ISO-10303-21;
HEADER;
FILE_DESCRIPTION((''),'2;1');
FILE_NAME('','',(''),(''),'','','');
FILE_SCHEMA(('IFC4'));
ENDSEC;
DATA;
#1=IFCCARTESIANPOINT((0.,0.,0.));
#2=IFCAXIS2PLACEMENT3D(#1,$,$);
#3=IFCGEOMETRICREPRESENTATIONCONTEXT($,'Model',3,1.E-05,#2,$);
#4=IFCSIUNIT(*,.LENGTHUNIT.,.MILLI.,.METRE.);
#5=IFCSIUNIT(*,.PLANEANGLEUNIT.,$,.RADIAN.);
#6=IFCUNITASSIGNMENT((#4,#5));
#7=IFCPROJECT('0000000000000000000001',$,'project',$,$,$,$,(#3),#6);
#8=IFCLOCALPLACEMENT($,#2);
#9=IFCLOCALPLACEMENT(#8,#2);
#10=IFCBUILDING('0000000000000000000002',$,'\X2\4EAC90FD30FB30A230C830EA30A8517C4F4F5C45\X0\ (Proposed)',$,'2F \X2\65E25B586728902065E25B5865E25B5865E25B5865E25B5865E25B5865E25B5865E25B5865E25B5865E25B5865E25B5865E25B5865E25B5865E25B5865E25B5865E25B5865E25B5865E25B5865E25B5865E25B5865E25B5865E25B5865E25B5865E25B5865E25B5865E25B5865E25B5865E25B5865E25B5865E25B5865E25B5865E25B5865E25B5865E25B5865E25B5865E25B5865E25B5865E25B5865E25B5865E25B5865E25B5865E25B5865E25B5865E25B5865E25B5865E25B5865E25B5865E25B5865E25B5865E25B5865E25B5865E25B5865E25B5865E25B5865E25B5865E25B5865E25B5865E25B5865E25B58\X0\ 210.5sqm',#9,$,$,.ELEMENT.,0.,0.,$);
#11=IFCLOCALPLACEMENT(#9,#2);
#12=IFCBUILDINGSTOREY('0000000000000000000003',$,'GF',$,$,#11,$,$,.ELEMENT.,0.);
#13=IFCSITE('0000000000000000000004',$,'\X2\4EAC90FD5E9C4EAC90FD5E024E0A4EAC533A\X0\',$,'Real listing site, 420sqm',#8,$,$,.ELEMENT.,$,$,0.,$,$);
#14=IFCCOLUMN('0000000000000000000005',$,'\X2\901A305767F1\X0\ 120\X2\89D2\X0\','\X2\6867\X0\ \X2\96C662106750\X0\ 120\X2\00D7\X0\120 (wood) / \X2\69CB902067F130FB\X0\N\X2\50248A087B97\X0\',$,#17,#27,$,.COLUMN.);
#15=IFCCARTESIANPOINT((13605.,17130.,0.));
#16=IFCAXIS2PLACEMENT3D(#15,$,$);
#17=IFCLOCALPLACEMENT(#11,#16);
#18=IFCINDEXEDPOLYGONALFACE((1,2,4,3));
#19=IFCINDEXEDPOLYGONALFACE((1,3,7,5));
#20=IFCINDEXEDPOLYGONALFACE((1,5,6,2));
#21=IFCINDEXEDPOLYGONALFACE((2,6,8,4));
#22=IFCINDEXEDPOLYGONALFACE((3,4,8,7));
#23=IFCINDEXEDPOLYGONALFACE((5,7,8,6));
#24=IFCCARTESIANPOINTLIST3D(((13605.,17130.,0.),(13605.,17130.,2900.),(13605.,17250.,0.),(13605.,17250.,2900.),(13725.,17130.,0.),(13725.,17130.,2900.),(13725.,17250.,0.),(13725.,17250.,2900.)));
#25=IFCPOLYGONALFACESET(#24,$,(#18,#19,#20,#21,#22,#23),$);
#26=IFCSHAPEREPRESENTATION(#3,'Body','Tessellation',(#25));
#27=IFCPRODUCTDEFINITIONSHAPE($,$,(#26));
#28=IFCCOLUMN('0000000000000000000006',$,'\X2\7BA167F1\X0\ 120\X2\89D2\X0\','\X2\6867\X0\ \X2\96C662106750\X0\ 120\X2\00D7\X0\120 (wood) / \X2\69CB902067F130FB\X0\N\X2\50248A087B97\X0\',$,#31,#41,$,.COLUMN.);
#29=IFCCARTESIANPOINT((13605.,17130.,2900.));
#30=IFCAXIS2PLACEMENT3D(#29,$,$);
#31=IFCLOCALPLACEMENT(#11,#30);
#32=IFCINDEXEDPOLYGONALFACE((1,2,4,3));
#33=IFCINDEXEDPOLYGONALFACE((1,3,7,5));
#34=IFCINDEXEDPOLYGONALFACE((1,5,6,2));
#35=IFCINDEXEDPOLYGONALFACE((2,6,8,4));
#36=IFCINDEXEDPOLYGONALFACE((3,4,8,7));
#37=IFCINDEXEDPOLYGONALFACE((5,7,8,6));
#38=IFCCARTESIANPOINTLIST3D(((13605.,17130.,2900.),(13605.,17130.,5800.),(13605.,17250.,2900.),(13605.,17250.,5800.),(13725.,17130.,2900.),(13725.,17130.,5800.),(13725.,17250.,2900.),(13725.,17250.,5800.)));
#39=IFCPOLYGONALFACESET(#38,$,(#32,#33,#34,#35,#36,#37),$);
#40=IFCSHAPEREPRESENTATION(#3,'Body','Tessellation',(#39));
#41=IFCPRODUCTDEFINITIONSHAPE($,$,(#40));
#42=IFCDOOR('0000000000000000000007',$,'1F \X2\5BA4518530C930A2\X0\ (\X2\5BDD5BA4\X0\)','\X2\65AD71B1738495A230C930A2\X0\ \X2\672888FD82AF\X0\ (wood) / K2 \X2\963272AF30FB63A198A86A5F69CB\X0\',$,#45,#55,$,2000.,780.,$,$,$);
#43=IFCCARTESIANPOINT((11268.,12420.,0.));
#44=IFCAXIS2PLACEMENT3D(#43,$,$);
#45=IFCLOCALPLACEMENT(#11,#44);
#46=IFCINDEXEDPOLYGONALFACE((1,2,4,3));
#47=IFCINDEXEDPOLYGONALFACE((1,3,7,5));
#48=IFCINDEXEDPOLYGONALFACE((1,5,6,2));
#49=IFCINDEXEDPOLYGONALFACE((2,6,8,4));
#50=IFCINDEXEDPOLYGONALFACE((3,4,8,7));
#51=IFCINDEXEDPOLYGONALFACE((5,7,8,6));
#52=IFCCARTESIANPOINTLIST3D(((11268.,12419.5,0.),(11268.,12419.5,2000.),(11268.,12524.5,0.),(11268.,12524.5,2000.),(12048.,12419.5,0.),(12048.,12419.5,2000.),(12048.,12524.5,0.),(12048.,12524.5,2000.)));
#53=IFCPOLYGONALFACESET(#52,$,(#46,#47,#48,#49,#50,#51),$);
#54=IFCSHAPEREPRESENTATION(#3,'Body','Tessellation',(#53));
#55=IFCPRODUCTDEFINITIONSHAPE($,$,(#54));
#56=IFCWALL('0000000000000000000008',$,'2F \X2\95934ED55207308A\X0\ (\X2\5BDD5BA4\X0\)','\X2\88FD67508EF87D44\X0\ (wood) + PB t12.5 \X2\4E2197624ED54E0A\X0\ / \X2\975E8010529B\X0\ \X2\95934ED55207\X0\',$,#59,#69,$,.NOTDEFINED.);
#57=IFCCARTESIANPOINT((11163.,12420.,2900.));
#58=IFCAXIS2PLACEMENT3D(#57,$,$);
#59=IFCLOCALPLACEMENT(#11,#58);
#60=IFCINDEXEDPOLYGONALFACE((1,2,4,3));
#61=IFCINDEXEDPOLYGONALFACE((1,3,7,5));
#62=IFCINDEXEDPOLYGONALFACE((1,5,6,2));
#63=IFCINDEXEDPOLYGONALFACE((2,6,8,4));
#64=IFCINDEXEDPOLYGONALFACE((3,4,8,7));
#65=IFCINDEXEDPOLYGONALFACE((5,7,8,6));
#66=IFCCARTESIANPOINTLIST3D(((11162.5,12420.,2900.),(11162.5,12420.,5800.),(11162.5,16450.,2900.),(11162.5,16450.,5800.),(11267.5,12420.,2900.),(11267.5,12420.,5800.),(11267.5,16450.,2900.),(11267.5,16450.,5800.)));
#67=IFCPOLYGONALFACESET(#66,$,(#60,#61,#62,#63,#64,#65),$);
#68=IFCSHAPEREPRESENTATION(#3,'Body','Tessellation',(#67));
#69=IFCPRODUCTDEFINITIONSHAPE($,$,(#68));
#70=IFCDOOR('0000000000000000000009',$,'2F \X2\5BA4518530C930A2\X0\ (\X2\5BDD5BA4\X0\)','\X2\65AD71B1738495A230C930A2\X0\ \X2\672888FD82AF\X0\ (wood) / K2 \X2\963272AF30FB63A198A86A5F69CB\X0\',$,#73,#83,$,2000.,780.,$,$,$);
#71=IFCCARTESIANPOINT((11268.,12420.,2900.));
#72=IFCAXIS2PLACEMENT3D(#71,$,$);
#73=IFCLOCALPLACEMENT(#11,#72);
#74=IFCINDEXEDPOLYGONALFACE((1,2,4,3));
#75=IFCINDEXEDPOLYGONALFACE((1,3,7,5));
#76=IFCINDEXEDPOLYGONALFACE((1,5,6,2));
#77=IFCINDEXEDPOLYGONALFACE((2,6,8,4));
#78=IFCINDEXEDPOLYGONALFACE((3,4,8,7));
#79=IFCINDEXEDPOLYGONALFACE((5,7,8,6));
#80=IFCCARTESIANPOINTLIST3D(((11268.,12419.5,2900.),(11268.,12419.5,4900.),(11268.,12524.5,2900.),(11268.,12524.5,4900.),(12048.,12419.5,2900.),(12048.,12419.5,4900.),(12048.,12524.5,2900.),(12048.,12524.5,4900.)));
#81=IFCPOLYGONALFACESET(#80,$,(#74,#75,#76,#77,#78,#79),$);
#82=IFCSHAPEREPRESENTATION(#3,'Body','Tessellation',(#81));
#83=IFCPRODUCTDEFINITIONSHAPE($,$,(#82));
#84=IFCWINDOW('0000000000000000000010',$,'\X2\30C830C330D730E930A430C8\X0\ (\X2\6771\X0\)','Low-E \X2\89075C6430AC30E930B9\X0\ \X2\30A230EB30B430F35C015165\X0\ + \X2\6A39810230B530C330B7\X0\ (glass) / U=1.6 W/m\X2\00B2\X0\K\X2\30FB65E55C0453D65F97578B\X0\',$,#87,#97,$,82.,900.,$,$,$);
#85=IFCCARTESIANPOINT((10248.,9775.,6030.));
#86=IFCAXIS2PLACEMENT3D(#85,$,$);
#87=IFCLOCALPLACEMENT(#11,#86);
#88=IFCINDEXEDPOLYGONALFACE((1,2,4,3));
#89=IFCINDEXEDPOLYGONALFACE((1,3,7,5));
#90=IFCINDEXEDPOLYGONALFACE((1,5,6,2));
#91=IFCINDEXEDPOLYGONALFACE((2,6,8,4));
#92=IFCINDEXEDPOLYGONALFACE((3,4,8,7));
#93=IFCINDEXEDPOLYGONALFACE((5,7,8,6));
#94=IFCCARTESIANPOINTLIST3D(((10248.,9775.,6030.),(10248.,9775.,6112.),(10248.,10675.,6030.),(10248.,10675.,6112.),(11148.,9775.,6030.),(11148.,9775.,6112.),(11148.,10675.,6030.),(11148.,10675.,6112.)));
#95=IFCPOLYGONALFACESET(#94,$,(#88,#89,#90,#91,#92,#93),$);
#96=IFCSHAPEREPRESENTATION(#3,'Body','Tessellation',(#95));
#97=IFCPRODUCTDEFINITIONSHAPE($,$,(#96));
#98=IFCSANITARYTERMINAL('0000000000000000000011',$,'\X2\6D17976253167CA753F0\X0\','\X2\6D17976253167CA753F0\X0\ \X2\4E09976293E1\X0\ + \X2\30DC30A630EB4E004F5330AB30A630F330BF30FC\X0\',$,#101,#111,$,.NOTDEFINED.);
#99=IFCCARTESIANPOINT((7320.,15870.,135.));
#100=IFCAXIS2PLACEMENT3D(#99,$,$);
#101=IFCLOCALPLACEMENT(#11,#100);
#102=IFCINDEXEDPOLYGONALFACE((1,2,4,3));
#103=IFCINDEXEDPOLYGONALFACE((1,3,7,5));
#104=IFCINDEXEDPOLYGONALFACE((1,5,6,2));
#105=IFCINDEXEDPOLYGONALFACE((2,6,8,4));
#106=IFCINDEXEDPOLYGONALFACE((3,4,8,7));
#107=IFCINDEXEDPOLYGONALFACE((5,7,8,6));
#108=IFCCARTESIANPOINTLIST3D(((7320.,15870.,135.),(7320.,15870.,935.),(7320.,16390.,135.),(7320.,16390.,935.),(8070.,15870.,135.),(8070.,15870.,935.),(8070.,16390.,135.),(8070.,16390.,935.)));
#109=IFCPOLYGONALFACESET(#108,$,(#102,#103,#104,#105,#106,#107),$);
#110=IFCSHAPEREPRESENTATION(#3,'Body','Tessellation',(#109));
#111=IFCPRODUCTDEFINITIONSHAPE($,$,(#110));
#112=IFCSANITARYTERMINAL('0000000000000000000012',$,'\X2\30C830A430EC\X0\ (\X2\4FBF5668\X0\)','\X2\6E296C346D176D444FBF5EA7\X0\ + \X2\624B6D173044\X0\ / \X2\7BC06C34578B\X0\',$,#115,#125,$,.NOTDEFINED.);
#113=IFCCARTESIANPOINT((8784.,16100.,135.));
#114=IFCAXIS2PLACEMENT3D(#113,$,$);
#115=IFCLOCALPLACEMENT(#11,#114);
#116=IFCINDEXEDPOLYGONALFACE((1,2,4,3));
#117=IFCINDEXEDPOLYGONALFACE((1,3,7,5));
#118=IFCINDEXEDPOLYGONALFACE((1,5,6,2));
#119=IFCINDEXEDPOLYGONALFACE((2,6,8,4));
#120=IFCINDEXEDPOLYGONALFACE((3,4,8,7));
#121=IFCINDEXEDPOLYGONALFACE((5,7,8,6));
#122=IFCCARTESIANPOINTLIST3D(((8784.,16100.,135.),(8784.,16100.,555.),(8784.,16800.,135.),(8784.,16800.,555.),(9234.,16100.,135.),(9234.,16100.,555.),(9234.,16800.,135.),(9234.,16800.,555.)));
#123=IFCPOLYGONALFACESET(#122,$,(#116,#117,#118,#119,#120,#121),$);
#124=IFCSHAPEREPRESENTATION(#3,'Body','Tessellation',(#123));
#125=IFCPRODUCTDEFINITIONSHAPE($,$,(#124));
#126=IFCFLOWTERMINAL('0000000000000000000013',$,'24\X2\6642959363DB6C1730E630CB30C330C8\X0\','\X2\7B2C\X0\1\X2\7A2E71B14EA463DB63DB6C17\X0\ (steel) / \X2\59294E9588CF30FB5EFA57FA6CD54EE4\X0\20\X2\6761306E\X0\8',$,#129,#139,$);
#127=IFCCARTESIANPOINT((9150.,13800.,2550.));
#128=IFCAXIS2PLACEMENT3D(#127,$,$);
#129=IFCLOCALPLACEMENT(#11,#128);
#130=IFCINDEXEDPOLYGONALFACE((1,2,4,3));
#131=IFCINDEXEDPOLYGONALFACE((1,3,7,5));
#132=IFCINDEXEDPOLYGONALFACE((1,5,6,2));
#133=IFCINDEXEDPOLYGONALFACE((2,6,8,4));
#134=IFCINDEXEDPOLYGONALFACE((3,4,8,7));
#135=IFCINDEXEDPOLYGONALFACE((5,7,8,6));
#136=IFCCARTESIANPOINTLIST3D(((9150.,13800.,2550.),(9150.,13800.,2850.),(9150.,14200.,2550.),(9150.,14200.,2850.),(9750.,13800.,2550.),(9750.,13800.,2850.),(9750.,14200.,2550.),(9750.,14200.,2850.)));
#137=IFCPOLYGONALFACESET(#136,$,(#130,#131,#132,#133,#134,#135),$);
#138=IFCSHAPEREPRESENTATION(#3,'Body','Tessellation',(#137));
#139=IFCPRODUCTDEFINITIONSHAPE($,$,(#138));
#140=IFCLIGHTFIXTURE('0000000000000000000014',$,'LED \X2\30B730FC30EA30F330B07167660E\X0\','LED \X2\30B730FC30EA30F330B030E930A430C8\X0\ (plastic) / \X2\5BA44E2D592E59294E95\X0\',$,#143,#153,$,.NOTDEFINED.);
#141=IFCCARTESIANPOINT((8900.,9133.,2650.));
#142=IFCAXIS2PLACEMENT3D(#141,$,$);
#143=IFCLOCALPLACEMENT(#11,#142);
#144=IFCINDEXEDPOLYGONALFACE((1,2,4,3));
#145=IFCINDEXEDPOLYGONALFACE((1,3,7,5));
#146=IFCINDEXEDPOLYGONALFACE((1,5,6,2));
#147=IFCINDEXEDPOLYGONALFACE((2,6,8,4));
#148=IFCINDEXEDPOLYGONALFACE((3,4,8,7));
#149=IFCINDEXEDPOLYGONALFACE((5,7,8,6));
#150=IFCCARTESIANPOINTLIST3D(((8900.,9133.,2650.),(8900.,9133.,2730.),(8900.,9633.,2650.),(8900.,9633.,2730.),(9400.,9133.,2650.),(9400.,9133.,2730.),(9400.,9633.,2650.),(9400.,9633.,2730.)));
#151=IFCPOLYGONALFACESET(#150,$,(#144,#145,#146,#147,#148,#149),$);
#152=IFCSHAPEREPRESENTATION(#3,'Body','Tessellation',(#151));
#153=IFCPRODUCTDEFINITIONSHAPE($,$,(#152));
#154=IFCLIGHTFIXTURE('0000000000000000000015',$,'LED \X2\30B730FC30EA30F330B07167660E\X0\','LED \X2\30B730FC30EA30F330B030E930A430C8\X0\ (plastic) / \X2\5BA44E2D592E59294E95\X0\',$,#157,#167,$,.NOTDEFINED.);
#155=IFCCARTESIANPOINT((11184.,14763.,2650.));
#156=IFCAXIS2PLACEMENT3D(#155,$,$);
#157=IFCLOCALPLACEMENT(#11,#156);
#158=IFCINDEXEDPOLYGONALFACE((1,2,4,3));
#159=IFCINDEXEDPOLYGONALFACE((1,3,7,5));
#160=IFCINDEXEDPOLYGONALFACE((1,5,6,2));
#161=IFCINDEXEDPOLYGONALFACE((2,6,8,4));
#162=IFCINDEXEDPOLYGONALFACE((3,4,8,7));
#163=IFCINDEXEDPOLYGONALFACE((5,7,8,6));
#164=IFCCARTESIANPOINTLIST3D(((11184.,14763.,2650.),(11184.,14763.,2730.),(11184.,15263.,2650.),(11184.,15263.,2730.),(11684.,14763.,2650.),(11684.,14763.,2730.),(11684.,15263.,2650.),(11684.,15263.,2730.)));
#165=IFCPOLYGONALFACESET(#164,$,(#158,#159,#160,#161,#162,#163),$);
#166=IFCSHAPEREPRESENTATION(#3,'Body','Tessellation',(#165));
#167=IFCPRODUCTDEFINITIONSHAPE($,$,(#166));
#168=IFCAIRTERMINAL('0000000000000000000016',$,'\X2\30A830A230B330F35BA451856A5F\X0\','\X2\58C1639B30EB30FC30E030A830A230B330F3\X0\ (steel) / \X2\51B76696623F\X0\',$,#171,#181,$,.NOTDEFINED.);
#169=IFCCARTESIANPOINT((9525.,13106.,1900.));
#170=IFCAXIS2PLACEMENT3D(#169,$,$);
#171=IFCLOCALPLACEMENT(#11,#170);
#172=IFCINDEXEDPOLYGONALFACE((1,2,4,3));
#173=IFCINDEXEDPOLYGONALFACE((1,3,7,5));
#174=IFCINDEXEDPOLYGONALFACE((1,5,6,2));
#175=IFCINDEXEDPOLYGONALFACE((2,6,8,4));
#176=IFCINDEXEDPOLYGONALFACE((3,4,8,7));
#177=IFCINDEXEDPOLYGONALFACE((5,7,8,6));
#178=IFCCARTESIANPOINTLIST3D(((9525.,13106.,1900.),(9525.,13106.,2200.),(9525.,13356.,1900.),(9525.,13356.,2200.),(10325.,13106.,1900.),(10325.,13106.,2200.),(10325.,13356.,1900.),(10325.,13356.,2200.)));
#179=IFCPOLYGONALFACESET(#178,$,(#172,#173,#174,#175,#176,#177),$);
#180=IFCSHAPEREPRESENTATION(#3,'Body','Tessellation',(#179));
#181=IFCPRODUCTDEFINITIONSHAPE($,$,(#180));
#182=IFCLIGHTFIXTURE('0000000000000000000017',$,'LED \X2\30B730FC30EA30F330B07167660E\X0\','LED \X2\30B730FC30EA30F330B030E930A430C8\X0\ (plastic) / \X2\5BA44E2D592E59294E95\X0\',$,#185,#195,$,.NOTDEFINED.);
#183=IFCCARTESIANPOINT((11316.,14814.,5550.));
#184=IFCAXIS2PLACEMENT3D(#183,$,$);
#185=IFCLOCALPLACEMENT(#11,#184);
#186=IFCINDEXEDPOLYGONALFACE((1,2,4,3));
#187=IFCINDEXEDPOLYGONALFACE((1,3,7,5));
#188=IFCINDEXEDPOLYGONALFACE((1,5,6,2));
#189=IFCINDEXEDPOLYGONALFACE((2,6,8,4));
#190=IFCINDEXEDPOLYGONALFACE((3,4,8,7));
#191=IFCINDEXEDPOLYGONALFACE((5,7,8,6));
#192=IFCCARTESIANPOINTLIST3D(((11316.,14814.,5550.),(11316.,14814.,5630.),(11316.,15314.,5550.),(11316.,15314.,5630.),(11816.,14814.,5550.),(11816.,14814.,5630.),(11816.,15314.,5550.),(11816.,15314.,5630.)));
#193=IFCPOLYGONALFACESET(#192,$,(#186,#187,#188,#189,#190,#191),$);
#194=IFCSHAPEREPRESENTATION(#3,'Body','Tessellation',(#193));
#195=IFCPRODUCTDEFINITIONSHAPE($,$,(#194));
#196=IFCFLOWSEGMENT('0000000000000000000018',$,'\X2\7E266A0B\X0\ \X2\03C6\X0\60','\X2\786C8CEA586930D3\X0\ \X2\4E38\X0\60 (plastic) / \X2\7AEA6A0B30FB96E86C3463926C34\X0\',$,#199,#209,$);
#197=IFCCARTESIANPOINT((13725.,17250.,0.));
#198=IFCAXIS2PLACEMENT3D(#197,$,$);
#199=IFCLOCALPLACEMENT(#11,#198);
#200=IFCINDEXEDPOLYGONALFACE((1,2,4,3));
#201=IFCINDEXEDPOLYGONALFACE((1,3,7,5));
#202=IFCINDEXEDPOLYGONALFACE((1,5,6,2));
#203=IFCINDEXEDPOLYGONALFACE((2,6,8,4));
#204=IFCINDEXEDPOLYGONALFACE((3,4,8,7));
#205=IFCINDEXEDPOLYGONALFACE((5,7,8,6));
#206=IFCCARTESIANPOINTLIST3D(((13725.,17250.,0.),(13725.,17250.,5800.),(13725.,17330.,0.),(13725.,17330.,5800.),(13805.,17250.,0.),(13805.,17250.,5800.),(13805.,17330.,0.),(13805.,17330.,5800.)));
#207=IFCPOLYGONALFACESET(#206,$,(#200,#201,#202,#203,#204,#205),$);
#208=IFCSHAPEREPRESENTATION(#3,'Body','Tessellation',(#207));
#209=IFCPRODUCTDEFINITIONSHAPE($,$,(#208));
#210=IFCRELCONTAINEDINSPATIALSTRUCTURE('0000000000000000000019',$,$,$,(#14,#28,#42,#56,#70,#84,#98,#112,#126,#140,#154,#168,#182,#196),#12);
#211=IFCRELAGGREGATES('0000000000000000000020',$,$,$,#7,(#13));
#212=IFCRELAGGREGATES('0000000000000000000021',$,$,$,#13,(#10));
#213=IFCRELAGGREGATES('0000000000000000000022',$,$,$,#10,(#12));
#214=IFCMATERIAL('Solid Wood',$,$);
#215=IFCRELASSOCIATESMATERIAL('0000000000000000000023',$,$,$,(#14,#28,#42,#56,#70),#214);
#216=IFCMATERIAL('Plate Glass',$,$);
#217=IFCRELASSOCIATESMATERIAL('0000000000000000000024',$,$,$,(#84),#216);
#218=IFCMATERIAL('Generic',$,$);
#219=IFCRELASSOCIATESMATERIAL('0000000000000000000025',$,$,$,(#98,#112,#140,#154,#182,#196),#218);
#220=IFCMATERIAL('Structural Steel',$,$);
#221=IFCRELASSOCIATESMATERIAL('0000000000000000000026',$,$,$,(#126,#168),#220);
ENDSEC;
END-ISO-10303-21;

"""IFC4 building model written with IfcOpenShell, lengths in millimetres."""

from ifc_helpers import new_model, si_unit, frame, frame_2d, origin, place, context, project, spatial, rectangle, extrude, material, element, save


model = new_model("IFC4")

# Units and contexts
model_context = context("Model", 3, precision=1e-05, world=origin())
ifc_project = project(units=[si_unit("LENGTHUNIT", "METRE", prefix="MILLI"), si_unit("PLANEANGLEUNIT", "RADIAN")], contexts=[model_context])

# Site, building, storey
site_placement = place(None, origin())
site = spatial("IfcSite", under=ifc_project, at=site_placement, Name="京都府京都市上京区", ObjectType="Real listing site, 420sqm", CompositionType="ELEMENT", RefElevation=0.0)
building_placement = place(site_placement, origin())
building = spatial("IfcBuilding", under=site, at=building_placement, Name="京都・アトリエ兼住居 (Proposed)", ObjectType="2F 既存木造既存既存既存既存既存既存既存既存既存既存既存既存既存既存既存既存既存既存既存既存既存既存既存既存既存既存既存既存既存既存既存既存既存既存既存既存既存既存既存既存既存既存既存既存既存既存既存既存既存既存既存既存既存既存既存既存既存既存 210.5sqm", CompositionType="ELEMENT", ElevationOfRefHeight=0.0, ElevationOfTerrain=0.0)
storey_placement = place(building_placement, origin())
storey = spatial("IfcBuildingStorey", under=building, at=storey_placement, Name="GF", CompositionType="ELEMENT", Elevation=0.0)

# Columns
ifc_material_1 = material(Name="Solid Wood")
column_1_placement = place(storey_placement, frame((13605.0, 17130.0, 0.0)))
element("IfcColumn", 1, at=column_1_placement, inside=storey, material=ifc_material_1, Name="通し柱 120角", Description="桧 集成材 120×120 (wood) / 構造柱・N値計算", PredefinedType="COLUMN", context=model_context, shape_type="SweptSolid", body=[
    extrude(rectangle(XDim=120.0, YDim=120.0, at=frame_2d((60.0, 60.0))), frame((13605.0, 17130.0, 0.0)), (0.0, 0.0, 1.0), 2900.0),
])
column_2_placement = place(storey_placement, frame((13605.0, 17130.0, 2900.0)))
element("IfcColumn", 2, at=column_2_placement, inside=storey, material=ifc_material_1, Name="管柱 120角", Description="桧 集成材 120×120 (wood) / 構造柱・N値計算", PredefinedType="COLUMN", context=model_context, shape_type="SweptSolid", body=[
    extrude(rectangle(XDim=120.0, YDim=120.0, at=frame_2d((60.0, 60.0))), frame((13605.0, 17130.0, 2900.0)), (0.0, 0.0, 1.0), 2900.0),
])

# Door
door_1_placement = place(storey_placement, frame((11268.0, 12420.0, 0.0)))
element("IfcDoor", 3, at=door_1_placement, inside=storey, material=ifc_material_1, Name="1F 室内ドア (寝室)", Description="断熱玄関ドア 木製芯 (wood) / K2 防犯・採風機構", OverallHeight=2000.0, OverallWidth=780.0, context=model_context, shape_type="SweptSolid", body=[
    extrude(rectangle(XDim=780.0, YDim=105.0, at=frame_2d((390.0, 52.0))), frame((11268.0, 12420.0, 0.0)), (0.0, 0.0, 1.0), 2000.0),
])

# Wall
wall_1_placement = place(storey_placement, frame((11163.0, 12420.0, 2900.0)))
element("IfcWall", 4, at=wall_1_placement, inside=storey, material=ifc_material_1, Name="2F 間仕切り (寝室)", Description="製材軸組 (wood) + PB t12.5 両面仕上 / 非耐力 間仕切", PredefinedType="NOTDEFINED", context=model_context, shape_type="SweptSolid", body=[
    extrude(rectangle(XDim=105.0, YDim=4030.0, at=frame_2d((52.0, 2015.0))), frame((11163.0, 12420.0, 2900.0)), (0.0, 0.0, 1.0), 2900.0),
])

# Door
door_2_placement = place(storey_placement, frame((11268.0, 12420.0, 2900.0)))
element("IfcDoor", 5, at=door_2_placement, inside=storey, material=ifc_material_1, Name="2F 室内ドア (寝室)", Description="断熱玄関ドア 木製芯 (wood) / K2 防犯・採風機構", OverallHeight=2000.0, OverallWidth=780.0, context=model_context, shape_type="SweptSolid", body=[
    extrude(rectangle(XDim=780.0, YDim=105.0, at=frame_2d((390.0, 52.0))), frame((11268.0, 12420.0, 2900.0)), (0.0, 0.0, 1.0), 2000.0),
])

# Window
ifc_material_2 = material(Name="Plate Glass")
window_placement = place(storey_placement, frame((10248.0, 9775.0, 6030.0)))
element("IfcWindow", 6, at=window_placement, inside=storey, material=ifc_material_2, Name="トップライト (東)", Description="Low-E 複層ガラス アルゴン封入 + 樹脂サッシ (glass) / U=1.6 W/m²K・日射取得型", OverallHeight=82.0, OverallWidth=900.0, context=model_context, shape_type="SweptSolid", body=[
    extrude(rectangle(XDim=900.0, YDim=900.0, at=frame_2d((450.0, 450.0))), frame((10248.0, 9775.0, 6030.0)), (0.0, 0.0, 1.0), 82.0),
])

# Sanitary terminals
ifc_material_3 = material(Name="Generic")
sanitary_terminal_1_placement = place(storey_placement, frame((7320.0, 15870.0, 135.0)))
element("IfcSanitaryTerminal", 7, at=sanitary_terminal_1_placement, inside=storey, material=ifc_material_3, Name="洗面化粧台", Description="洗面化粧台 三面鏡 + ボウル一体カウンター", PredefinedType="NOTDEFINED", context=model_context, shape_type="SweptSolid", body=[
    extrude(rectangle(XDim=750.0, YDim=520.0, at=frame_2d((375.0, 260.0))), frame((7320.0, 15870.0, 135.0)), (0.0, 0.0, 1.0), 800.0),
])
sanitary_terminal_2_placement = place(storey_placement, frame((8784.0, 16100.0, 135.0)))
element("IfcSanitaryTerminal", 8, at=sanitary_terminal_2_placement, inside=storey, material=ifc_material_3, Name="トイレ (便器)", Description="温水洗浄便座 + 手洗い / 節水型", PredefinedType="NOTDEFINED", context=model_context, shape_type="SweptSolid", body=[
    extrude(rectangle(XDim=450.0, YDim=700.0, at=frame_2d((225.0, 350.0))), frame((8784.0, 16100.0, 135.0)), (0.0, 0.0, 1.0), 420.0),
])

# Flow terminal
ifc_material_4 = material(Name="Structural Steel")
flow_terminal_placement = place(storey_placement, frame((9150.0, 13800.0, 2550.0)))
element("IfcFlowTerminal", 9, at=flow_terminal_placement, inside=storey, material=ifc_material_4, Name="24時間換気ユニット", Description="第1種熱交換換気 (steel) / 天井裏・建基法令20条の8", context=model_context, shape_type="SweptSolid", body=[
    extrude(rectangle(XDim=600.0, YDim=400.0, at=frame_2d((300.0, 200.0))), frame((9150.0, 13800.0, 2550.0)), (0.0, 0.0, 1.0), 300.0),
])

# Light fixtures
light_fixture_1_placement = place(storey_placement, frame((8900.0, 9133.0, 2650.0)))
element("IfcLightFixture", 10, at=light_fixture_1_placement, inside=storey, material=ifc_material_3, Name="LED シーリング照明", Description="LED シーリングライト (plastic) / 室中央天井", PredefinedType="NOTDEFINED", context=model_context, shape_type="SweptSolid", body=[
    extrude(rectangle(XDim=500.0, YDim=500.0, at=frame_2d((250.0, 250.0))), frame((8900.0, 9133.0, 2650.0)), (0.0, 0.0, 1.0), 80.0),
])
light_fixture_2_placement = place(storey_placement, frame((11184.0, 14763.0, 2650.0)))
element("IfcLightFixture", 11, at=light_fixture_2_placement, inside=storey, material=ifc_material_3, Name="LED シーリング照明", Description="LED シーリングライト (plastic) / 室中央天井", PredefinedType="NOTDEFINED", context=model_context, shape_type="SweptSolid", body=[
    extrude(rectangle(XDim=500.0, YDim=500.0, at=frame_2d((250.0, 250.0))), frame((11184.0, 14763.0, 2650.0)), (0.0, 0.0, 1.0), 80.0),
])

# Air terminal
air_terminal_placement = place(storey_placement, frame((9525.0, 13106.0, 1900.0)))
element("IfcAirTerminal", 12, at=air_terminal_placement, inside=storey, material=ifc_material_4, Name="エアコン室内機", Description="壁掛ルームエアコン (steel) / 冷暖房", PredefinedType="NOTDEFINED", context=model_context, shape_type="SweptSolid", body=[
    extrude(rectangle(XDim=800.0, YDim=250.0, at=frame_2d((400.0, 125.0))), frame((9525.0, 13106.0, 1900.0)), (0.0, 0.0, 1.0), 300.0),
])

# Light fixture
light_fixture_3_placement = place(storey_placement, frame((11316.0, 14814.0, 5550.0)))
element("IfcLightFixture", 13, at=light_fixture_3_placement, inside=storey, material=ifc_material_3, Name="LED シーリング照明", Description="LED シーリングライト (plastic) / 室中央天井", PredefinedType="NOTDEFINED", context=model_context, shape_type="SweptSolid", body=[
    extrude(rectangle(XDim=500.0, YDim=500.0, at=frame_2d((250.0, 250.0))), frame((11316.0, 14814.0, 5550.0)), (0.0, 0.0, 1.0), 80.0),
])

# Flow segment
flow_segment_placement = place(storey_placement, frame((13725.0, 17250.0, 0.0)))
element("IfcFlowSegment", 14, at=flow_segment_placement, inside=storey, material=ifc_material_3, Name="縦樋 φ60", Description="硬質塩ビ 丸60 (plastic) / 竪樋・雨水排水", context=model_context, shape_type="SweptSolid", body=[
    extrude(rectangle(XDim=80.0, YDim=80.0, at=frame_2d((40.0, 40.0))), frame((13725.0, 17250.0, 0.0)), (0.0, 0.0, 1.0), 5800.0),
])

save(model, "model.ifc")
